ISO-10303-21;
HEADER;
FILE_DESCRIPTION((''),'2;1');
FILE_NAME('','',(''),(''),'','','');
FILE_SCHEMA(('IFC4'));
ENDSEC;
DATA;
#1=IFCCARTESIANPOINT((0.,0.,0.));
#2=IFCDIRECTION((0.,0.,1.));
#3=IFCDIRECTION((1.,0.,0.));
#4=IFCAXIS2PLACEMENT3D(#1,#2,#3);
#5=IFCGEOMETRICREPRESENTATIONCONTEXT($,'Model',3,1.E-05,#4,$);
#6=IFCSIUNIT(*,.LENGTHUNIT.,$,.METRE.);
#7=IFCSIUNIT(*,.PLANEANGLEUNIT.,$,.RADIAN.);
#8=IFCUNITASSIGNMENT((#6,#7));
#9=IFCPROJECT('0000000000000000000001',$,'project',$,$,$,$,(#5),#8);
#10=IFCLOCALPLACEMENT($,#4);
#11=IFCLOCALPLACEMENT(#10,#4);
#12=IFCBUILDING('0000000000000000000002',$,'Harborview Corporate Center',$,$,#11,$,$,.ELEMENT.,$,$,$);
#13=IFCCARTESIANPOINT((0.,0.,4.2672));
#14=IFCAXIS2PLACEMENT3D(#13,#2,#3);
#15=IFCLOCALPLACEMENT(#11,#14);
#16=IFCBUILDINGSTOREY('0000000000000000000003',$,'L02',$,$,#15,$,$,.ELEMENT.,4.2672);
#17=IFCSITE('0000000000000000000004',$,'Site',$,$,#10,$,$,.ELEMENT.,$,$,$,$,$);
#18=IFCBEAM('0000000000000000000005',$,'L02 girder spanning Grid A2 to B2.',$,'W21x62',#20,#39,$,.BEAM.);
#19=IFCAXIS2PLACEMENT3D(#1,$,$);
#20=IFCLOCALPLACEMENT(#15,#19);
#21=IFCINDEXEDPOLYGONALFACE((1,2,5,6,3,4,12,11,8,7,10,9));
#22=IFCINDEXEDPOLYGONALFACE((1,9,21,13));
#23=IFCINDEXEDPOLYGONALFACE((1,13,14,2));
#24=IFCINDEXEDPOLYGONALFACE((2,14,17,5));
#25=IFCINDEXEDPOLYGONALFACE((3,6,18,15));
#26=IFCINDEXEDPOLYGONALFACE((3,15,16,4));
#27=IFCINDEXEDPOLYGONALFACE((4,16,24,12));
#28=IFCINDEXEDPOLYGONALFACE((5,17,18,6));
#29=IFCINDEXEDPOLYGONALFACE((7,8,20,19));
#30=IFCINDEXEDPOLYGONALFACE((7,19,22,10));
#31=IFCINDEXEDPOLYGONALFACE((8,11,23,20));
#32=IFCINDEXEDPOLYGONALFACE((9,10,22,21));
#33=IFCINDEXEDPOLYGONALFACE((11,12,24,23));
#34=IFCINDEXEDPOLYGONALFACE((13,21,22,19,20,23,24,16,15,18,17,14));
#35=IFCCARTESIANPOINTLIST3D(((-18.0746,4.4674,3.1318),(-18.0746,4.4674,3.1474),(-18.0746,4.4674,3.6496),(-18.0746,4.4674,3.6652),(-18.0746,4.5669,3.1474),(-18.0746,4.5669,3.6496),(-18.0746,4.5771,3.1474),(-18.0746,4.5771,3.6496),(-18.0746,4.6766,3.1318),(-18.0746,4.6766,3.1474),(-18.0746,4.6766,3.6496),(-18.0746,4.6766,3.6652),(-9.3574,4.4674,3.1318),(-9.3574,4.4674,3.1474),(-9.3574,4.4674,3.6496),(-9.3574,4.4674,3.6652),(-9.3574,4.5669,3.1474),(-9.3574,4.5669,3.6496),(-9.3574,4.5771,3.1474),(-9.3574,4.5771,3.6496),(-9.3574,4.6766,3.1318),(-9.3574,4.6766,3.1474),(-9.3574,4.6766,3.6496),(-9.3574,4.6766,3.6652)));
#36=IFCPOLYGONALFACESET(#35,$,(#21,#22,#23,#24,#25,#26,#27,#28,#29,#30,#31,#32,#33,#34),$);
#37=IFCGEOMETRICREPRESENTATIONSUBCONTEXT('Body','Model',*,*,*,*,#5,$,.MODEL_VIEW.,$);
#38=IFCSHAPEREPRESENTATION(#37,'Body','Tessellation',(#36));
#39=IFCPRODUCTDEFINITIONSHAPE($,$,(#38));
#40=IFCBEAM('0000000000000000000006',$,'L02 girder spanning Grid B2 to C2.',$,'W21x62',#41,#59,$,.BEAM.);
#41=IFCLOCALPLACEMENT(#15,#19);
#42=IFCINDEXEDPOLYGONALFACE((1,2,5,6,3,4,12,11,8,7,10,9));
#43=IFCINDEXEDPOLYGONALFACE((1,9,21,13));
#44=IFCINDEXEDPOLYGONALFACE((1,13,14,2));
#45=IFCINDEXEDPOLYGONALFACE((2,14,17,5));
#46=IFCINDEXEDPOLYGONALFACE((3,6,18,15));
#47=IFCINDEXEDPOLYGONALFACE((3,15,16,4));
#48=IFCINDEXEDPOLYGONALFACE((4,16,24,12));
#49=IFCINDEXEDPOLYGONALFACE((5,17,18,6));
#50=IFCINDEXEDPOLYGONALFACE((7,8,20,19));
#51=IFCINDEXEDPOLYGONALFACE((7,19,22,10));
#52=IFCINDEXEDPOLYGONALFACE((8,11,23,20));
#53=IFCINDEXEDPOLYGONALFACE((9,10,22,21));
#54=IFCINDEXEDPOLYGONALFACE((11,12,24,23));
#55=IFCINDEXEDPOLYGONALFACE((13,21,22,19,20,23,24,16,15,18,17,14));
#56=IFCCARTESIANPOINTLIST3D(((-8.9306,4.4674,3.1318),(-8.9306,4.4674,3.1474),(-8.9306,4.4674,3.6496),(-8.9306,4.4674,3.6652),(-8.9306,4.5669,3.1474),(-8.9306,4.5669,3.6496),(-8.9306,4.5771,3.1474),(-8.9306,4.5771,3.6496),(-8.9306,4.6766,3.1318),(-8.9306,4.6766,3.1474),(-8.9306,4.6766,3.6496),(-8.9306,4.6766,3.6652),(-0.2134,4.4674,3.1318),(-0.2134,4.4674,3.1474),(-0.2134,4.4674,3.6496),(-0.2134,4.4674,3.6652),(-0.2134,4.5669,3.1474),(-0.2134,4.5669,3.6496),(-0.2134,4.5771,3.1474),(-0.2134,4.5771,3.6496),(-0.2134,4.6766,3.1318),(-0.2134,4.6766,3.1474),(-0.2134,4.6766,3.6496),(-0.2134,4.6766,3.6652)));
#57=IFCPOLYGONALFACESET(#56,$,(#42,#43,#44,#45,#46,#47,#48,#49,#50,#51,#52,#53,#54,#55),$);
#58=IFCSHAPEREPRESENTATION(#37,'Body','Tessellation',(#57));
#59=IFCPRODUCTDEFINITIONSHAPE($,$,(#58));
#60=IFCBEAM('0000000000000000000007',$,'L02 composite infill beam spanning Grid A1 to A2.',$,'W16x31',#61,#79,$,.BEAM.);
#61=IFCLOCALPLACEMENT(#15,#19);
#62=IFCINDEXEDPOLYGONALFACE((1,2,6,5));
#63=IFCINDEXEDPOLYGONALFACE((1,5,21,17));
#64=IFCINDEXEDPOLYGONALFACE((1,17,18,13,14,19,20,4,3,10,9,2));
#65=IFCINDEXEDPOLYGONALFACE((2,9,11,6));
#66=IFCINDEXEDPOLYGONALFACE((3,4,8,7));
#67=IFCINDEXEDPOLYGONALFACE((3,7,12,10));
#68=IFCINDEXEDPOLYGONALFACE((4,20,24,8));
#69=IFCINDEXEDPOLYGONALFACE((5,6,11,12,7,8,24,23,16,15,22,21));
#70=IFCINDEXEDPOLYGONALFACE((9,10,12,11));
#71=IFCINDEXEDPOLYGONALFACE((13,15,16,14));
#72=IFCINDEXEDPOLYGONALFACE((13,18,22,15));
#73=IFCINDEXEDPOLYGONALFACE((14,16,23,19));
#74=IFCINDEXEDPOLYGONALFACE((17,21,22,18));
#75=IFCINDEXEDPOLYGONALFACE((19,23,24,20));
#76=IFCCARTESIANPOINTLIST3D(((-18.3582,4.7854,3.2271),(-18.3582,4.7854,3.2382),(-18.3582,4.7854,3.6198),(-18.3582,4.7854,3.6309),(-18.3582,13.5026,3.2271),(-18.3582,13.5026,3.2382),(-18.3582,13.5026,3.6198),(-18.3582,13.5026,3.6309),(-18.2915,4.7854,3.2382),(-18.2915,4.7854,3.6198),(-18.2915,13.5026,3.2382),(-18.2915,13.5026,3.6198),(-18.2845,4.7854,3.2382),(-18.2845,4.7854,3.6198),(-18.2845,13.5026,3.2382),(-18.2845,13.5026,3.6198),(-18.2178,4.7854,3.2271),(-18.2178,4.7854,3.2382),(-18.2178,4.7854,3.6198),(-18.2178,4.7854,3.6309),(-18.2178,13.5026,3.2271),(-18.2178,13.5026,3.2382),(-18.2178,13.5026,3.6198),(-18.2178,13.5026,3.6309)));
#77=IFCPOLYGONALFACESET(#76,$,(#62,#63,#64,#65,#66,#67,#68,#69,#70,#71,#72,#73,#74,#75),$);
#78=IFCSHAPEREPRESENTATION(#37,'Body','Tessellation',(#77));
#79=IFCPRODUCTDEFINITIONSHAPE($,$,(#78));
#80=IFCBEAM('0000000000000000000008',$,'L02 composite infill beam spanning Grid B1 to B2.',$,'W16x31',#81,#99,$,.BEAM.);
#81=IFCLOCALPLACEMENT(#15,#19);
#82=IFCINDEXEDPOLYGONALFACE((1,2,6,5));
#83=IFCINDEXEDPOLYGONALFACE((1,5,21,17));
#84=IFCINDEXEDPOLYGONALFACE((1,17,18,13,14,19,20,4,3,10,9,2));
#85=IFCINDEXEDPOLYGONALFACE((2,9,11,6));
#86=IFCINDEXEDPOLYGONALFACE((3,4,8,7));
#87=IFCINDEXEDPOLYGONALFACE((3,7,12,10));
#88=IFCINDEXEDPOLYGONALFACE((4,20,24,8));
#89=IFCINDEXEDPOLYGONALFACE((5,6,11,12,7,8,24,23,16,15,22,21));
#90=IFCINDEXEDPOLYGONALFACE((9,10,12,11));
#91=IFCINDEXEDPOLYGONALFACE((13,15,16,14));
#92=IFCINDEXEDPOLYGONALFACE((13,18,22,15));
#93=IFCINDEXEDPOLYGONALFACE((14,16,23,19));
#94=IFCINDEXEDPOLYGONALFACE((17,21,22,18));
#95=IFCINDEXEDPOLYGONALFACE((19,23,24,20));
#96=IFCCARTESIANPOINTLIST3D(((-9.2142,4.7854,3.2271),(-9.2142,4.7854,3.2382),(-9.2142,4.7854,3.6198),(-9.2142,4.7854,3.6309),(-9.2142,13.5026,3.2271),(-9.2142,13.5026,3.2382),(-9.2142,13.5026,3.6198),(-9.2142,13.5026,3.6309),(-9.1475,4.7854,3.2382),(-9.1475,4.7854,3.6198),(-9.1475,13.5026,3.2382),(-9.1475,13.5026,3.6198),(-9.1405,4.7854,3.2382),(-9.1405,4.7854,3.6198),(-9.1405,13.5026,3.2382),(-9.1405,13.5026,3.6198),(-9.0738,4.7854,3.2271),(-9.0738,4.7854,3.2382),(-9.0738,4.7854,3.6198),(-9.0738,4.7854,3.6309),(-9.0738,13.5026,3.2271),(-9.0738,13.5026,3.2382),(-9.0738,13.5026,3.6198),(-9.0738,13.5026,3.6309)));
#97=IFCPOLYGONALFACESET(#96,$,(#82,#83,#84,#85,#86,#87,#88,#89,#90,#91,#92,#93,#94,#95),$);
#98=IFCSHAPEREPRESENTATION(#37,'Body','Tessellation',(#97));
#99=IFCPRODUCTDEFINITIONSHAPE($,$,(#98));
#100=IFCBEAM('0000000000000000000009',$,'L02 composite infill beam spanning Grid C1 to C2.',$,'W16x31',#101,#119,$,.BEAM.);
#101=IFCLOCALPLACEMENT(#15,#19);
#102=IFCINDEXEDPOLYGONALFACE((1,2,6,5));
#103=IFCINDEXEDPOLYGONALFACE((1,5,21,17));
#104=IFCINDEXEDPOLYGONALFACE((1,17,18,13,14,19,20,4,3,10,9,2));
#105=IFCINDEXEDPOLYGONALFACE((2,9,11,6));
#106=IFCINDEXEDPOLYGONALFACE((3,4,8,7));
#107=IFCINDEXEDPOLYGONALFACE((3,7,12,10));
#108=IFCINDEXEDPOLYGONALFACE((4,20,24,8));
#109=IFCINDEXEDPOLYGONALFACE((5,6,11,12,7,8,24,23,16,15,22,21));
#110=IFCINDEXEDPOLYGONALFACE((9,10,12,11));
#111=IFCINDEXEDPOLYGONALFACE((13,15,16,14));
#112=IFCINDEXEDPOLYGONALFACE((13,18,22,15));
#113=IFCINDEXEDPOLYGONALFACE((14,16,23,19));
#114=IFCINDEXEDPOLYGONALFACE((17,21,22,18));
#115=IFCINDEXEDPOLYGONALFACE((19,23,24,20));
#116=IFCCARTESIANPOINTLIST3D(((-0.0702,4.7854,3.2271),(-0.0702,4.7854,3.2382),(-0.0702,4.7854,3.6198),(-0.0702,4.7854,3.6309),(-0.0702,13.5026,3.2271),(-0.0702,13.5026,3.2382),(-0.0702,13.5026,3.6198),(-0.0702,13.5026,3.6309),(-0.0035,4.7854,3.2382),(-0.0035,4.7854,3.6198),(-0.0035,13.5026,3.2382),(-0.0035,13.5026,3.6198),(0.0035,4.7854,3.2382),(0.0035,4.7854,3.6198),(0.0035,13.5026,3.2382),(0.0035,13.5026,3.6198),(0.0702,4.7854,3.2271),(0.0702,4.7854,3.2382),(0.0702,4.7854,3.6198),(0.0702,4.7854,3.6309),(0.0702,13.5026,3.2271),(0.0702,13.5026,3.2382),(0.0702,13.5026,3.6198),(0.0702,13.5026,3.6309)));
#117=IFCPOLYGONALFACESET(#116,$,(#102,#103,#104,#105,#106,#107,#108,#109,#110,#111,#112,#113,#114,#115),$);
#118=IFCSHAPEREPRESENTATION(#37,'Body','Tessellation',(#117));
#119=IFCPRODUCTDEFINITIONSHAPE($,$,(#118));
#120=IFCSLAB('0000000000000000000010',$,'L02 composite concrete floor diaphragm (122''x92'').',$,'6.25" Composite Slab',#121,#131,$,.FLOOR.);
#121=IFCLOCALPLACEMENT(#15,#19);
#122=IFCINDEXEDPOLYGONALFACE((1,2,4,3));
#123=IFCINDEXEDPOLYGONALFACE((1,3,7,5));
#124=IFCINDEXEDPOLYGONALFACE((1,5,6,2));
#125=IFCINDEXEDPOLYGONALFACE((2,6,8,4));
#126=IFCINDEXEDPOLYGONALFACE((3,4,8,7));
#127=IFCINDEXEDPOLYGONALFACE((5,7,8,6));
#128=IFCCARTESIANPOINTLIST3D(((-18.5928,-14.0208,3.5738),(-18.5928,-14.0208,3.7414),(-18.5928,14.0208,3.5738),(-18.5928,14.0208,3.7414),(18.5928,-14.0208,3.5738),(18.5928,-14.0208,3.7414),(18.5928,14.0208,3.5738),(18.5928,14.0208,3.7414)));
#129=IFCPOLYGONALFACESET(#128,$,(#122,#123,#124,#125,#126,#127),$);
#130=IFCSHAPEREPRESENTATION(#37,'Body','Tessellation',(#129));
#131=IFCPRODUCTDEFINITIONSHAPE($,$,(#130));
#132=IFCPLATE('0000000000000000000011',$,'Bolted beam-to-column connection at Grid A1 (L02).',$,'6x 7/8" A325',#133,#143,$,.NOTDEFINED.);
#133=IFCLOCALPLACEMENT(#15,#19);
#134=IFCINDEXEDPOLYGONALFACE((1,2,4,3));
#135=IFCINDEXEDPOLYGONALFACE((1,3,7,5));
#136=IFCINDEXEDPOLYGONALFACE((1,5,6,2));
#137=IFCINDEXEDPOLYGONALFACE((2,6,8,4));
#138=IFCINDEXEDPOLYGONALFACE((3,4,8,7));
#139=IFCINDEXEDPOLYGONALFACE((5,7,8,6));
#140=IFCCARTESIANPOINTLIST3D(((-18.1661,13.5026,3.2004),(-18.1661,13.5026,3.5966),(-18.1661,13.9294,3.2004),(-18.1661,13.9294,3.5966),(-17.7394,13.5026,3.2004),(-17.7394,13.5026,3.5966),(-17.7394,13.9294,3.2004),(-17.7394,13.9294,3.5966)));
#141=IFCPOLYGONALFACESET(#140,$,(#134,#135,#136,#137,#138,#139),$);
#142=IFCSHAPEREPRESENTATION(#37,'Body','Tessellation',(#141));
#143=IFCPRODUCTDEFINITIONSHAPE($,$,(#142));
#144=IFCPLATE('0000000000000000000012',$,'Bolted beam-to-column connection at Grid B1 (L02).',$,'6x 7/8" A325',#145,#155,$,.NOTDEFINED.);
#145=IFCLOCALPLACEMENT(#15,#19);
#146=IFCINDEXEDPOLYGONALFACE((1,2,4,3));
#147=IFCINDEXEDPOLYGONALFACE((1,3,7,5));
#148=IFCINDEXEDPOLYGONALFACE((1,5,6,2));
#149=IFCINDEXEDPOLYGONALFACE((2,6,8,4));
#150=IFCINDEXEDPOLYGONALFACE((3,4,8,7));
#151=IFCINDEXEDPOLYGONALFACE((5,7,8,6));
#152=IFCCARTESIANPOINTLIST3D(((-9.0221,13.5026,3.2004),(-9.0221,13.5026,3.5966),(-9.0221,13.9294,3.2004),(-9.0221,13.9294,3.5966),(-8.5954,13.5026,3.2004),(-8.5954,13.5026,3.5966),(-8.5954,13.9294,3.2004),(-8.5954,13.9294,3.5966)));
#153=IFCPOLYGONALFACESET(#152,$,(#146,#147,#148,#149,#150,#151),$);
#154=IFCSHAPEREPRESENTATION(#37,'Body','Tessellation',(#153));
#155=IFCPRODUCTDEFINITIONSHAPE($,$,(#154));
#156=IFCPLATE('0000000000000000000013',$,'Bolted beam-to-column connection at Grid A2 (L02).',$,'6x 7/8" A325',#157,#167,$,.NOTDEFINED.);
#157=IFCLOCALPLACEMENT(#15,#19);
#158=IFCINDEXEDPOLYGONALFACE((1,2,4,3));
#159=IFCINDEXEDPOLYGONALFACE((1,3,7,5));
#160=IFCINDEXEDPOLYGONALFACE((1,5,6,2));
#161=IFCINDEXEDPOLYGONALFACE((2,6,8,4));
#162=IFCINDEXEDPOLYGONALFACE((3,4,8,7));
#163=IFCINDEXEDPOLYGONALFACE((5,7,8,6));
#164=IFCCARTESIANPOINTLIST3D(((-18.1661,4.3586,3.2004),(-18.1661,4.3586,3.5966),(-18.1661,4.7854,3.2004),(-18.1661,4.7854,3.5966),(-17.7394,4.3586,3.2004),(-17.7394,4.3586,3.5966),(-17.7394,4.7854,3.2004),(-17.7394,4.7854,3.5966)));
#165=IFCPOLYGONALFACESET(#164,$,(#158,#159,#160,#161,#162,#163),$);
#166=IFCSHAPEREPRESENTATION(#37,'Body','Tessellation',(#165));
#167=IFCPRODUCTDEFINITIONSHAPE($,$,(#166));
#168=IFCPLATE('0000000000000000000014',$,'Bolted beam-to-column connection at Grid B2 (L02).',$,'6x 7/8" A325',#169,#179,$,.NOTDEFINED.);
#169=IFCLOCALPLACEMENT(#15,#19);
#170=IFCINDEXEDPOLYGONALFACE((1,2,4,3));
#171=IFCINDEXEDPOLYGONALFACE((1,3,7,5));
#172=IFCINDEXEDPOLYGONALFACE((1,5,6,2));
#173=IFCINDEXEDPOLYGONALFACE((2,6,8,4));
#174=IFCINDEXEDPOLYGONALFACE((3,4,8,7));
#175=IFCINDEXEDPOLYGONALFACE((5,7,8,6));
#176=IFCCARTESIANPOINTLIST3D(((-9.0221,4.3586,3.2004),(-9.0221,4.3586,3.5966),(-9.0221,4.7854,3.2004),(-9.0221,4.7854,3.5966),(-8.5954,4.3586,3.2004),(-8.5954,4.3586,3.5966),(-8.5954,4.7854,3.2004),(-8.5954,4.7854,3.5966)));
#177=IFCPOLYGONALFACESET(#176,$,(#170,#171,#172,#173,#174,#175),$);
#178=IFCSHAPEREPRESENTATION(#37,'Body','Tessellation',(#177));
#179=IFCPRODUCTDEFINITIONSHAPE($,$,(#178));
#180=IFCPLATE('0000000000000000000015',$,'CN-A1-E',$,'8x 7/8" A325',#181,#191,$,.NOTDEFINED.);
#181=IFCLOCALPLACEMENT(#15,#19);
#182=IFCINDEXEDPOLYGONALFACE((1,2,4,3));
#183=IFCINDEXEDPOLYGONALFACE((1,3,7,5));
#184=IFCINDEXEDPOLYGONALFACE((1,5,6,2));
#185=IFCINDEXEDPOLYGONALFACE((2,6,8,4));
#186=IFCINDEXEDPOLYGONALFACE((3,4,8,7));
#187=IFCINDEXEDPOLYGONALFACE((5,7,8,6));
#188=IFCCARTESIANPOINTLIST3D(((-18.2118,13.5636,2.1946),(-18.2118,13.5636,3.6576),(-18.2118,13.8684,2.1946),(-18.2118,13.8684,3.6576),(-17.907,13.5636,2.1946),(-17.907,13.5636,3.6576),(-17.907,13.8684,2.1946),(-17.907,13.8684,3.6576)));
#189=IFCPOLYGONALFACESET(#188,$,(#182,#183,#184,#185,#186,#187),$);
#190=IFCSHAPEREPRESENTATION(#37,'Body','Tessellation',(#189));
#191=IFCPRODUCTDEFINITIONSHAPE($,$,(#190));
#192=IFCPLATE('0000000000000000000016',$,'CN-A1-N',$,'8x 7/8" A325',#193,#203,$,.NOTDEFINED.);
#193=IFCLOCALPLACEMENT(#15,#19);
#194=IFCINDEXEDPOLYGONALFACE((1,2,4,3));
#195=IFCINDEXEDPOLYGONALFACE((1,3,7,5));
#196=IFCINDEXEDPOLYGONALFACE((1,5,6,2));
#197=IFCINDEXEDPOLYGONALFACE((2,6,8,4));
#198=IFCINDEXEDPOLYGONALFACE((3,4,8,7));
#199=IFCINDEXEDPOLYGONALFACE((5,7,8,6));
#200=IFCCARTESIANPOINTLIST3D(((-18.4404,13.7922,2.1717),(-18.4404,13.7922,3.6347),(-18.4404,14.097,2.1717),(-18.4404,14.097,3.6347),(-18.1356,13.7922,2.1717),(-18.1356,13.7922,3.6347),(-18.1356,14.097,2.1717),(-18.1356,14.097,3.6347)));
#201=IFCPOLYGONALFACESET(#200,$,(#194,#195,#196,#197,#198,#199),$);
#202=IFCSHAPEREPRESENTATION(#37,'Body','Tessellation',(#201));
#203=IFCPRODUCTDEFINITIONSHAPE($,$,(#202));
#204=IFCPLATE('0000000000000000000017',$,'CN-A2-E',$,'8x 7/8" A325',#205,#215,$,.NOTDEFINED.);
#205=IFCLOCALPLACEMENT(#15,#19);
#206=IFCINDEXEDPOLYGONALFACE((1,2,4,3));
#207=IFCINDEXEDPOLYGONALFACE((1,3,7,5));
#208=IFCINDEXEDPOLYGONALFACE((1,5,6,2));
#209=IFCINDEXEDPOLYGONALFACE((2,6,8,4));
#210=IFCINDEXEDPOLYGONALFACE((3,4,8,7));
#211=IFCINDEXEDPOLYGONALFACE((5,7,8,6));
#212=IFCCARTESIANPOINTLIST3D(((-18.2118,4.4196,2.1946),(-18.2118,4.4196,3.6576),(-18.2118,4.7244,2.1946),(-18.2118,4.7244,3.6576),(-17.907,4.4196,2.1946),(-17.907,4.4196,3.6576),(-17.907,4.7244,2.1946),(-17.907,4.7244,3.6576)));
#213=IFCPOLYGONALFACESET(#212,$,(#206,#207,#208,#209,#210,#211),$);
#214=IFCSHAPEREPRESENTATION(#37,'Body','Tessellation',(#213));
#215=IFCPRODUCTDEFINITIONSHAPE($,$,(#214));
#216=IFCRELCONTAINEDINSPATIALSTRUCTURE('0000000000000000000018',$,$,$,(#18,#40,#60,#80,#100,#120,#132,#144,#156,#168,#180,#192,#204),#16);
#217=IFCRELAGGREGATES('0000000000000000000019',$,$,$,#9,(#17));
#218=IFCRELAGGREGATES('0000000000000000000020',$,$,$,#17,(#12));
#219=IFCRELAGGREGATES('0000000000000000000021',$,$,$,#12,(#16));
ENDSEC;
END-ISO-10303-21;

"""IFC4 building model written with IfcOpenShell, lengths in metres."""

from ifc_helpers import new_model, si_unit, frame, origin_with_axes, place, context, subcontext, project, spatial, rectangle, i_section, extrude, element, save


model = new_model("IFC4")

# Units and contexts
model_context = context("Model", 3, precision=1e-05, world=origin_with_axes())
body_context = subcontext(model_context, "Body", "Model", "MODEL_VIEW")
ifc_project = project(units=[si_unit("LENGTHUNIT", "METRE"), si_unit("PLANEANGLEUNIT", "RADIAN")], contexts=[model_context])

# Site, building, storey
site_placement = place(None, origin_with_axes())
site = spatial("IfcSite", under=ifc_project, at=site_placement, Name="Site", CompositionType="ELEMENT")
building_placement = place(site_placement, origin_with_axes())
building = spatial("IfcBuilding", under=site, at=building_placement, Name="Harborview Corporate Center", CompositionType="ELEMENT")
storey_placement = place(building_placement, frame((0.0, 0.0, 4.2672), z_axis=(0.0, 0.0, 1.0), x_axis=(1.0, 0.0, 0.0)))
storey = spatial("IfcBuildingStorey", under=building, at=storey_placement, Name="L02", CompositionType="ELEMENT", Elevation=4.2672)

# Beams
beam_1_placement = place(storey_placement, frame((-18.0746, 4.572, 3.3985), z_axis=(1.0, 0.0, 0.0), x_axis=(0.0, 1.0, 0.0)))
element("IfcBeam", 1, at=beam_1_placement, inside=storey, Name="L02 girder spanning Grid A2 to B2.", ObjectType="W21x62", PredefinedType="BEAM", context=body_context, shape_type="SweptSolid", body=[
    extrude(i_section(OverallWidth=0.2093, OverallDepth=0.5334, WebThickness=0.0102, FlangeThickness=0.0156), origin_with_axes(), (0.0, 0.0, 1.0), 8.7173),
])
beam_2_placement = place(storey_placement, frame((-8.9306, 4.572, 3.3985), z_axis=(1.0, 0.0, 0.0), x_axis=(0.0, 1.0, 0.0)))
element("IfcBeam", 2, at=beam_2_placement, inside=storey, Name="L02 girder spanning Grid B2 to C2.", ObjectType="W21x62", PredefinedType="BEAM", context=body_context, shape_type="SweptSolid", body=[
    extrude(i_section(OverallWidth=0.2093, OverallDepth=0.5334, WebThickness=0.0102, FlangeThickness=0.0156), origin_with_axes(), (0.0, 0.0, 1.0), 8.7173),
])
for number, where, z_axis, x_axis, name in (
    (3, (-18.288, 4.7854, 3.429), (0.0, 1.0, 0.0), (-1.0, 0.0, 0.0), "L02 composite infill beam spanning Grid A1 to A2."),
    (4, (-9.144, 4.7854, 3.429), (0.0, 1.0, 0.0), (-1.0, 0.0, 0.0), "L02 composite infill beam spanning Grid B1 to B2."),
    (5, (0.0, 4.7854, 3.429), (0.0, 1.0, 0.0), (-1.0, 0.0, 0.0), "L02 composite infill beam spanning Grid C1 to C2."),
):
    element("IfcBeam", number, at=place(storey_placement, frame(where, z_axis=z_axis, x_axis=x_axis)), inside=storey, Name=name, ObjectType="W16x31", PredefinedType="BEAM", context=body_context, shape_type="SweptSolid", body=[
        extrude(i_section(OverallWidth=0.1405, OverallDepth=0.4039, WebThickness=0.007, FlangeThickness=0.0112), origin_with_axes(), (0.0, 0.0, 1.0), 8.7173),
    ])

# Slab
slab_placement = place(storey_placement, frame((0.0, 0.0, 3.5738), z_axis=(0.0, 0.0, 1.0), x_axis=(1.0, 0.0, 0.0)))
element("IfcSlab", 6, at=slab_placement, inside=storey, Name="L02 composite concrete floor diaphragm (122'x92').", ObjectType="6.25\" Composite Slab", PredefinedType="FLOOR", context=body_context, shape_type="SweptSolid", body=[
    extrude(rectangle(XDim=37.1856, YDim=28.0416), origin_with_axes(), (0.0, 0.0, 1.0), 0.1676),
])

# Plates
plate_1_placement = place(storey_placement, frame((-17.9527, 13.716, 3.2004), z_axis=(0.0, 0.0, 1.0), x_axis=(1.0, 0.0, 0.0)))
element("IfcPlate", 7, at=plate_1_placement, inside=storey, Name="Bolted beam-to-column connection at Grid A1 (L02).", ObjectType="6x 7/8\" A325", PredefinedType="NOTDEFINED", context=body_context, shape_type="SweptSolid", body=[
    extrude(rectangle(XDim=0.4267, YDim=0.4267), origin_with_axes(), (0.0, 0.0, 1.0), 0.3962),
])
plate_2_placement = place(storey_placement, frame((-8.8087, 13.716, 3.2004), z_axis=(0.0, 0.0, 1.0), x_axis=(1.0, 0.0, 0.0)))
element("IfcPlate", 8, at=plate_2_placement, inside=storey, Name="Bolted beam-to-column connection at Grid B1 (L02).", ObjectType="6x 7/8\" A325", PredefinedType="NOTDEFINED", context=body_context, shape_type="SweptSolid", body=[
    extrude(rectangle(XDim=0.4267, YDim=0.4267), origin_with_axes(), (0.0, 0.0, 1.0), 0.3962),
])
plate_3_placement = place(storey_placement, frame((-17.9527, 4.572, 3.2004), z_axis=(0.0, 0.0, 1.0), x_axis=(1.0, 0.0, 0.0)))
element("IfcPlate", 9, at=plate_3_placement, inside=storey, Name="Bolted beam-to-column connection at Grid A2 (L02).", ObjectType="6x 7/8\" A325", PredefinedType="NOTDEFINED", context=body_context, shape_type="SweptSolid", body=[
    extrude(rectangle(XDim=0.4267, YDim=0.4267), origin_with_axes(), (0.0, 0.0, 1.0), 0.3962),
])
plate_4_placement = place(storey_placement, frame((-8.8087, 4.572, 3.2004), z_axis=(0.0, 0.0, 1.0), x_axis=(1.0, 0.0, 0.0)))
element("IfcPlate", 10, at=plate_4_placement, inside=storey, Name="Bolted beam-to-column connection at Grid B2 (L02).", ObjectType="6x 7/8\" A325", PredefinedType="NOTDEFINED", context=body_context, shape_type="SweptSolid", body=[
    extrude(rectangle(XDim=0.4267, YDim=0.4267), origin_with_axes(), (0.0, 0.0, 1.0), 0.3962),
])
for number, where, z_axis, x_axis, name in (
    (11, (-18.0594, 13.716, 2.1946), (0.0, 0.0, 1.0), (1.0, 0.0, 0.0), "CN-A1-E"),
    (12, (-18.288, 13.9446, 2.1717), (0.0, 0.0, 1.0), (1.0, 0.0, 0.0), "CN-A1-N"),
    (13, (-18.0594, 4.572, 2.1946), (0.0, 0.0, 1.0), (1.0, 0.0, 0.0), "CN-A2-E"),
):
    element("IfcPlate", number, at=place(storey_placement, frame(where, z_axis=z_axis, x_axis=x_axis)), inside=storey, Name=name, ObjectType="8x 7/8\" A325", PredefinedType="NOTDEFINED", context=body_context, shape_type="SweptSolid", body=[
        extrude(rectangle(XDim=0.3048, YDim=0.3048), origin_with_axes(), (0.0, 0.0, 1.0), 1.463),
    ])

save(model, "model.ifc")
